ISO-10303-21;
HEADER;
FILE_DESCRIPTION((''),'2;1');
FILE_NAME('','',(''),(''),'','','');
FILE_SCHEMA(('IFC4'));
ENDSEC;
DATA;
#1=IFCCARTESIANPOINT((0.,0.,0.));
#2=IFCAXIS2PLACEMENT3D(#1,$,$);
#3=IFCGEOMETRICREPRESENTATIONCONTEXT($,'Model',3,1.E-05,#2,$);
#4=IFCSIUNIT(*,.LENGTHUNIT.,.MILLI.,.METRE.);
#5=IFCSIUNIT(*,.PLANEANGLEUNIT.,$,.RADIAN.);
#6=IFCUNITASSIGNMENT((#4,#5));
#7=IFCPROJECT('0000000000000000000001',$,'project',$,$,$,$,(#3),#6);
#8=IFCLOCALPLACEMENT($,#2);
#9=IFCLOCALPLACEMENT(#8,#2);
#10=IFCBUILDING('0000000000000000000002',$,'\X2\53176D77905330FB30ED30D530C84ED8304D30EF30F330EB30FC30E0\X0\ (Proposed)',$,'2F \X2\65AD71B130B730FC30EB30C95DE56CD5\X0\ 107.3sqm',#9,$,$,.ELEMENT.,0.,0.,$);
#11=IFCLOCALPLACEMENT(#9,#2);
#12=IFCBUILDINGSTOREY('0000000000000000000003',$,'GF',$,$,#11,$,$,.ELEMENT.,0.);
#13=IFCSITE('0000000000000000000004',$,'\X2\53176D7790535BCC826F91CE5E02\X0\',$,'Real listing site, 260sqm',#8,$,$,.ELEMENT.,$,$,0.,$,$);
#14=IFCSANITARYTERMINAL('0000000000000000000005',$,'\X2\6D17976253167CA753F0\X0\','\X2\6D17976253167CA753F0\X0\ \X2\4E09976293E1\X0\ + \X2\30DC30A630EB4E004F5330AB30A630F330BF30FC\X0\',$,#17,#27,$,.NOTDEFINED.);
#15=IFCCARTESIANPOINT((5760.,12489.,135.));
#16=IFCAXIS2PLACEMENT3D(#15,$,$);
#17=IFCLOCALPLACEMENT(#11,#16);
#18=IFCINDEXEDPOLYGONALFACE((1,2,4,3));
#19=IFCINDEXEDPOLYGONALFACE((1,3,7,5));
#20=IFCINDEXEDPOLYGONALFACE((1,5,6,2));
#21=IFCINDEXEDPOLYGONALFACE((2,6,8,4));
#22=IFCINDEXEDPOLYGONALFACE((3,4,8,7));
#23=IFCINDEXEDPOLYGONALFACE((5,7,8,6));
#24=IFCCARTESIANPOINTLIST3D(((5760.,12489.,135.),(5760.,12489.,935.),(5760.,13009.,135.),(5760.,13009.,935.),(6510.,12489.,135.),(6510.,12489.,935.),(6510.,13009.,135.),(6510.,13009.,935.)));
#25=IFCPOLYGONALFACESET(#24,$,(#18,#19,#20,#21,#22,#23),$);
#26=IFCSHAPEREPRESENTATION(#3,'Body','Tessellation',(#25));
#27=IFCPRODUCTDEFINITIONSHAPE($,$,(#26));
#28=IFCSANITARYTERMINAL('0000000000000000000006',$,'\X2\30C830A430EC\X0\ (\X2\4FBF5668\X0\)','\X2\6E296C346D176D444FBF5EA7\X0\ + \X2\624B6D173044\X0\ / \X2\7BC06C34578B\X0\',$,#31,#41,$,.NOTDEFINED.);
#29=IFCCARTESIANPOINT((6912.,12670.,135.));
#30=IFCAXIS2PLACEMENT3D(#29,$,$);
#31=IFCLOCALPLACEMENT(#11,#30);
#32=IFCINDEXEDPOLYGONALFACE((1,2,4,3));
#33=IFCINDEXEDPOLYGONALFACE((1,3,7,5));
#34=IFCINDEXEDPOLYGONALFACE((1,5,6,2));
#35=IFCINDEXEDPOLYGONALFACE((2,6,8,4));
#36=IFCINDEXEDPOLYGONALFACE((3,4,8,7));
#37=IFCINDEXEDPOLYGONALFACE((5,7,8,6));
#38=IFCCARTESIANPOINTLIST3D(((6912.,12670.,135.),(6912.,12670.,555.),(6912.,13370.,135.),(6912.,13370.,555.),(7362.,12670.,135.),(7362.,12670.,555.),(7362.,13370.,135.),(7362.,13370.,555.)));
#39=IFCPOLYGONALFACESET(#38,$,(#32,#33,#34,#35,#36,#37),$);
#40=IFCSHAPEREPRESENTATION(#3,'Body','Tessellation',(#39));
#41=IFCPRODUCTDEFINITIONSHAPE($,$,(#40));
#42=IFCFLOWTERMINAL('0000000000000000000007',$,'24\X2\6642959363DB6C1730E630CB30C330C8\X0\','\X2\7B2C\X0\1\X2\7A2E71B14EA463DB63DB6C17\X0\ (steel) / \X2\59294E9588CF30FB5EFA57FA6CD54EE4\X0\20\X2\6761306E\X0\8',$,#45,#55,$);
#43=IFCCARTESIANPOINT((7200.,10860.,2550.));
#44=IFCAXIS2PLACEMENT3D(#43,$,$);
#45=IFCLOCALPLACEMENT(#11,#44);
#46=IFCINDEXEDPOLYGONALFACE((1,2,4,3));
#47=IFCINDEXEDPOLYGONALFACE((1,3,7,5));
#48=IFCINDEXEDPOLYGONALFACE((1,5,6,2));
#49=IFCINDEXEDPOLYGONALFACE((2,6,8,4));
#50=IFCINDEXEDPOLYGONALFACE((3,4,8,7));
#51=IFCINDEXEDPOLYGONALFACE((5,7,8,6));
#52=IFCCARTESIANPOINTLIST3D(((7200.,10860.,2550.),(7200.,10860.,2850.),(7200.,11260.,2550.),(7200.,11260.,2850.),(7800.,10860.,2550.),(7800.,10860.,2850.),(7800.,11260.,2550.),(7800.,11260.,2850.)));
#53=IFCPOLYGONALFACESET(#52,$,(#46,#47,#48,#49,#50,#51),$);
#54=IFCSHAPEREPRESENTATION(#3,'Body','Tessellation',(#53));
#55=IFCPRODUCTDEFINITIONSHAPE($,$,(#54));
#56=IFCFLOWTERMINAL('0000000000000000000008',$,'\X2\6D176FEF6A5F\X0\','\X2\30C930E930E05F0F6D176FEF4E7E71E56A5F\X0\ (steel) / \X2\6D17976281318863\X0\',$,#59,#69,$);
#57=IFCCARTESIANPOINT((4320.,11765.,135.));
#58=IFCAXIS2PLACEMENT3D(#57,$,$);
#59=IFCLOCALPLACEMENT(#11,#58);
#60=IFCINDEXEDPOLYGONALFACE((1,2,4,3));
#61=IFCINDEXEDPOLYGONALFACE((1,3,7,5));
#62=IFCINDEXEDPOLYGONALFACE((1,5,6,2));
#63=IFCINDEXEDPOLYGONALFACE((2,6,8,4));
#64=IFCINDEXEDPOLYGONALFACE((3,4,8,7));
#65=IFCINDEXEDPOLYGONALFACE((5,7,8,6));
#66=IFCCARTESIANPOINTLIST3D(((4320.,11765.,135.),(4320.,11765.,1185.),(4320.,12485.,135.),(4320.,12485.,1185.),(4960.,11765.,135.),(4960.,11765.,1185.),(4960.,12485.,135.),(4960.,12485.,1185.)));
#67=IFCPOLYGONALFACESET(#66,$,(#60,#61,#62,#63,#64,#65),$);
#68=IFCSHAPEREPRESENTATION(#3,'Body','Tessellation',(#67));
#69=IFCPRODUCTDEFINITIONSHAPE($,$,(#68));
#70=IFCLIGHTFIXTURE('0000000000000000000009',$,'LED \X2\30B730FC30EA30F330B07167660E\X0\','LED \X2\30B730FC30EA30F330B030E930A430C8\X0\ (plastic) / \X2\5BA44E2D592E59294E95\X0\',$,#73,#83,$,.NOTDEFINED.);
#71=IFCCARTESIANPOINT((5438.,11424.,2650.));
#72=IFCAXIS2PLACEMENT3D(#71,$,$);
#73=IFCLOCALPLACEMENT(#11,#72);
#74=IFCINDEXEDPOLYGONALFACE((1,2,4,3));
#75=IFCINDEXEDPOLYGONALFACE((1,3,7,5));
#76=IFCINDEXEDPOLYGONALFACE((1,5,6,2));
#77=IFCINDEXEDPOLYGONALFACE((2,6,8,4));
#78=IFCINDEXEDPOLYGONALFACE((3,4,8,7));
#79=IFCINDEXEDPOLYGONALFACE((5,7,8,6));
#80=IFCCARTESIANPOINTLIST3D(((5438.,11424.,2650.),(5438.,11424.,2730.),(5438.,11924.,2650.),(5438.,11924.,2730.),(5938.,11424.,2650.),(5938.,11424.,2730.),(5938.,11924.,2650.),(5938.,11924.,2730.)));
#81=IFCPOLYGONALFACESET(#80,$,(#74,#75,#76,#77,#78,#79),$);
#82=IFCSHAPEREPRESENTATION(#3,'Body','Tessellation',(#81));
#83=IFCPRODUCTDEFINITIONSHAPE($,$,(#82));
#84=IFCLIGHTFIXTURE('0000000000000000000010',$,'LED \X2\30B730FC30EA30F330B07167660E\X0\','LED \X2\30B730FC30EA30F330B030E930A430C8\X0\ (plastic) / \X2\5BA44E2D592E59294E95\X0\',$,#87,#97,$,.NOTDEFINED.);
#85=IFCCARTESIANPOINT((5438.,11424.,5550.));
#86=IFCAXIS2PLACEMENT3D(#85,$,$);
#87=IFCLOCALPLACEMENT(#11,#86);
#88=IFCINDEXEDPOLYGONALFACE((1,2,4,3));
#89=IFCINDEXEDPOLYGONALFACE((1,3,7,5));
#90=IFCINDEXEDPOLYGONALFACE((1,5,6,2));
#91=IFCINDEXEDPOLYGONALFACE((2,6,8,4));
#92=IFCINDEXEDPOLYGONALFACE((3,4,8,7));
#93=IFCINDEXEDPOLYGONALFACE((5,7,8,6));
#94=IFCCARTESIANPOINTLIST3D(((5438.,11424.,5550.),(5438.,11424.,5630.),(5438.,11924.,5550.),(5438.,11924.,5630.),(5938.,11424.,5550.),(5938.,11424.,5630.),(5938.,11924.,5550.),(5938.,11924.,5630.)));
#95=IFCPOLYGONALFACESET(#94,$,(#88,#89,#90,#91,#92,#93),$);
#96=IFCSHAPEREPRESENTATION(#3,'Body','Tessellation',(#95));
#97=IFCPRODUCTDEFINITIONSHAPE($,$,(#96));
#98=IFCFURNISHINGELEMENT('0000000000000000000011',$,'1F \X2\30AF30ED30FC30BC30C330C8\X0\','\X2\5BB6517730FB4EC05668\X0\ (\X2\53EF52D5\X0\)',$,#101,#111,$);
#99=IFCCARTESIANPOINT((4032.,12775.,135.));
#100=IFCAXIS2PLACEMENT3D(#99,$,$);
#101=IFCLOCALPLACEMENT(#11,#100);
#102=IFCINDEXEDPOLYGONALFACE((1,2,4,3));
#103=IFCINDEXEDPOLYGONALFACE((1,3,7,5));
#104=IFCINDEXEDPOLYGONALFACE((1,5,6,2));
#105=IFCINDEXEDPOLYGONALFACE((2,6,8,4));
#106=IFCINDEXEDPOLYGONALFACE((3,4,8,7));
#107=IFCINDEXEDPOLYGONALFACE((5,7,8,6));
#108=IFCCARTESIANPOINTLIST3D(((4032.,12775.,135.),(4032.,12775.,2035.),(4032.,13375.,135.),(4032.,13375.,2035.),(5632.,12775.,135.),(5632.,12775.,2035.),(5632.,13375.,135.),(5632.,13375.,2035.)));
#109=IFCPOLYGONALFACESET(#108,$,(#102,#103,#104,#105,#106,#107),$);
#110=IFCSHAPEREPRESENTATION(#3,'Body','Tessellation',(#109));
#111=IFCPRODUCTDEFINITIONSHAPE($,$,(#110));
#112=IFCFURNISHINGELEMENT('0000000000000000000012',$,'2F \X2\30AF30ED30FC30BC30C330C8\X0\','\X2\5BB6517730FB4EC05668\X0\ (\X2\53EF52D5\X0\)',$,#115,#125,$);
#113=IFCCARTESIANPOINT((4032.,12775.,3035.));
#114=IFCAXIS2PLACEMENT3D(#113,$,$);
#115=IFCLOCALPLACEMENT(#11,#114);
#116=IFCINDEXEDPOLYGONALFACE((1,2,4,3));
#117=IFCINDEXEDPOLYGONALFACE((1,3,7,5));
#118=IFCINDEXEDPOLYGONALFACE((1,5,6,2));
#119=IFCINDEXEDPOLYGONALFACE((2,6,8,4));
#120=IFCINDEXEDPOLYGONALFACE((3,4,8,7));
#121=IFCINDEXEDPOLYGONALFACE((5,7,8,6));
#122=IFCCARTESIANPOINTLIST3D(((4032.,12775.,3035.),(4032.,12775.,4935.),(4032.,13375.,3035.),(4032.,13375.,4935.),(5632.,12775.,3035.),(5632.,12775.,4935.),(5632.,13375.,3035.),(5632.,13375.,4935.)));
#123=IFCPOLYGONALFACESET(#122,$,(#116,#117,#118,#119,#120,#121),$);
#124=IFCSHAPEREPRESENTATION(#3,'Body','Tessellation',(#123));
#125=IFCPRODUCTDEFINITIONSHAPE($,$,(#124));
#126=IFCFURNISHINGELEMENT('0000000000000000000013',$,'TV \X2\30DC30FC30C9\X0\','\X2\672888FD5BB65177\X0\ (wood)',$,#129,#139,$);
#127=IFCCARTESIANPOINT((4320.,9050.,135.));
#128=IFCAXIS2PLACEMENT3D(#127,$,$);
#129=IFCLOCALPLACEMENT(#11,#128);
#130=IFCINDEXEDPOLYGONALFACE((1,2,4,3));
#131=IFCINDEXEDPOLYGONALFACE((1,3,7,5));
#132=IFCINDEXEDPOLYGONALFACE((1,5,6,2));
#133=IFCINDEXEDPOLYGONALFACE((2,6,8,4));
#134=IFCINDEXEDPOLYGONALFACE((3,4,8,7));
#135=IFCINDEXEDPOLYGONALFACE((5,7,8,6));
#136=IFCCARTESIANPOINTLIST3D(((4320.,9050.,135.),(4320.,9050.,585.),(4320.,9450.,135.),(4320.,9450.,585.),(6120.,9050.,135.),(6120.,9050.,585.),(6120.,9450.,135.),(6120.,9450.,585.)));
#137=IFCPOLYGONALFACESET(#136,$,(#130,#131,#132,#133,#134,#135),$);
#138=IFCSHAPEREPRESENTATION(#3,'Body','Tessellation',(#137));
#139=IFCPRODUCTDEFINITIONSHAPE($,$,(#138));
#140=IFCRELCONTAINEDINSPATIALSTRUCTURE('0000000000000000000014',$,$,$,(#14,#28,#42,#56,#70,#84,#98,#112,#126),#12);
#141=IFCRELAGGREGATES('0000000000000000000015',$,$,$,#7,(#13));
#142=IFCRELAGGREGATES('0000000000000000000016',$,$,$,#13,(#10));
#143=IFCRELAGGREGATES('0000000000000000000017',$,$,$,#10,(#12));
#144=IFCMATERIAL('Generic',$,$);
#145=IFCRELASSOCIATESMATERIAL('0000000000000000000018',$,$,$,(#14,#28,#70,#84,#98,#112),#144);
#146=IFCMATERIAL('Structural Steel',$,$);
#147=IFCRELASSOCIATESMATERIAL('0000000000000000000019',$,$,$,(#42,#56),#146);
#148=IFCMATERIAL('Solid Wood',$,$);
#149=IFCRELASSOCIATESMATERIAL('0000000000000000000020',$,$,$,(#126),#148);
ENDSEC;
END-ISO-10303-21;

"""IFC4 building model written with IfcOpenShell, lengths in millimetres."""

from ifc_helpers import new_model, si_unit, frame, frame_2d, origin, place, context, project, spatial, rectangle, extrude, material, element, save


model = new_model("IFC4")

# Units and contexts
model_context = context("Model", 3, precision=1e-05, world=origin())
ifc_project = project(units=[si_unit("LENGTHUNIT", "METRE", prefix="MILLI"), si_unit("PLANEANGLEUNIT", "RADIAN")], contexts=[model_context])

# Site, building, storey
site_placement = place(None, origin())
site = spatial("IfcSite", under=ifc_project, at=site_placement, Name="北海道富良野市", ObjectType="Real listing site, 260sqm", CompositionType="ELEMENT", RefElevation=0.0)
building_placement = place(site_placement, origin())
building = spatial("IfcBuilding", under=site, at=building_placement, Name="北海道・ロフト付きワンルーム (Proposed)", ObjectType="2F 断熱シールド工法 107.3sqm", CompositionType="ELEMENT", ElevationOfRefHeight=0.0, ElevationOfTerrain=0.0)
storey_placement = place(building_placement, origin())
storey = spatial("IfcBuildingStorey", under=building, at=storey_placement, Name="GF", CompositionType="ELEMENT", Elevation=0.0)

# Shared definitions
ifc_material_1 = material(Name="Solid Wood")

# Sanitary terminals
ifc_material_2 = material(Name="Generic")
sanitary_terminal_1_placement = place(storey_placement, frame((5760.0, 12489.0, 135.0)))
element("IfcSanitaryTerminal", 1, at=sanitary_terminal_1_placement, inside=storey, material=ifc_material_2, Name="洗面化粧台", Description="洗面化粧台 三面鏡 + ボウル一体カウンター", PredefinedType="NOTDEFINED", context=model_context, shape_type="SweptSolid", body=[
    extrude(rectangle(XDim=750.0, YDim=520.0, at=frame_2d((375.0, 260.0))), frame((5760.0, 12489.0, 135.0)), (0.0, 0.0, 1.0), 800.0),
])
sanitary_terminal_2_placement = place(storey_placement, frame((6912.0, 12670.0, 135.0)))
element("IfcSanitaryTerminal", 2, at=sanitary_terminal_2_placement, inside=storey, material=ifc_material_2, Name="トイレ (便器)", Description="温水洗浄便座 + 手洗い / 節水型", PredefinedType="NOTDEFINED", context=model_context, shape_type="SweptSolid", body=[
    extrude(rectangle(XDim=450.0, YDim=700.0, at=frame_2d((225.0, 350.0))), frame((6912.0, 12670.0, 135.0)), (0.0, 0.0, 1.0), 420.0),
])

# Flow terminals
ifc_material_3 = material(Name="Structural Steel")
flow_terminal_1_placement = place(storey_placement, frame((7200.0, 10860.0, 2550.0)))
element("IfcFlowTerminal", 3, at=flow_terminal_1_placement, inside=storey, material=ifc_material_3, Name="24時間換気ユニット", Description="第1種熱交換換気 (steel) / 天井裏・建基法令20条の8", context=model_context, shape_type="SweptSolid", body=[
    extrude(rectangle(XDim=600.0, YDim=400.0, at=frame_2d((300.0, 200.0))), frame((7200.0, 10860.0, 2550.0)), (0.0, 0.0, 1.0), 300.0),
])
flow_terminal_2_placement = place(storey_placement, frame((4320.0, 11765.0, 135.0)))
element("IfcFlowTerminal", 4, at=flow_terminal_2_placement, inside=storey, material=ifc_material_3, Name="洗濯機", Description="ドラム式洗濯乾燥機 (steel) / 洗面脱衣", context=model_context, shape_type="SweptSolid", body=[
    extrude(rectangle(XDim=640.0, YDim=720.0, at=frame_2d((320.0, 360.0))), frame((4320.0, 11765.0, 135.0)), (0.0, 0.0, 1.0), 1050.0),
])

# Light fixtures
light_fixture_1_placement = place(storey_placement, frame((5438.0, 11424.0, 2650.0)))
element("IfcLightFixture", 5, at=light_fixture_1_placement, inside=storey, material=ifc_material_2, Name="LED シーリング照明", Description="LED シーリングライト (plastic) / 室中央天井", PredefinedType="NOTDEFINED", context=model_context, shape_type="SweptSolid", body=[
    extrude(rectangle(XDim=500.0, YDim=500.0, at=frame_2d((250.0, 250.0))), frame((5438.0, 11424.0, 2650.0)), (0.0, 0.0, 1.0), 80.0),
])
light_fixture_2_placement = place(storey_placement, frame((5438.0, 11424.0, 5550.0)))
element("IfcLightFixture", 6, at=light_fixture_2_placement, inside=storey, material=ifc_material_2, Name="LED シーリング照明", Description="LED シーリングライト (plastic) / 室中央天井", PredefinedType="NOTDEFINED", context=model_context, shape_type="SweptSolid", body=[
    extrude(rectangle(XDim=500.0, YDim=500.0, at=frame_2d((250.0, 250.0))), frame((5438.0, 11424.0, 5550.0)), (0.0, 0.0, 1.0), 80.0),
])

# Furnishing elements
furnishing_1_placement = place(storey_placement, frame((4032.0, 12775.0, 135.0)))
element("IfcFurnishingElement", 7, at=furnishing_1_placement, inside=storey, material=ifc_material_2, Name="1F クローゼット", Description="家具・什器 (可動)", context=model_context, shape_type="SweptSolid", body=[
    extrude(rectangle(XDim=1600.0, YDim=600.0, at=frame_2d((800.0, 300.0))), frame((4032.0, 12775.0, 135.0)), (0.0, 0.0, 1.0), 1900.0),
])
furnishing_2_placement = place(storey_placement, frame((4032.0, 12775.0, 3035.0)))
element("IfcFurnishingElement", 8, at=furnishing_2_placement, inside=storey, material=ifc_material_2, Name="2F クローゼット", Description="家具・什器 (可動)", context=model_context, shape_type="SweptSolid", body=[
    extrude(rectangle(XDim=1600.0, YDim=600.0, at=frame_2d((800.0, 300.0))), frame((4032.0, 12775.0, 3035.0)), (0.0, 0.0, 1.0), 1900.0),
])
furnishing_3_placement = place(storey_placement, frame((4320.0, 9050.0, 135.0)))
element("IfcFurnishingElement", 9, at=furnishing_3_placement, inside=storey, material=ifc_material_1, Name="TV ボード", Description="木製家具 (wood)", context=model_context, shape_type="SweptSolid", body=[
    extrude(rectangle(XDim=1800.0, YDim=400.0, at=frame_2d((900.0, 200.0))), frame((4320.0, 9050.0, 135.0)), (0.0, 0.0, 1.0), 450.0),
])

save(model, "model.ifc")
